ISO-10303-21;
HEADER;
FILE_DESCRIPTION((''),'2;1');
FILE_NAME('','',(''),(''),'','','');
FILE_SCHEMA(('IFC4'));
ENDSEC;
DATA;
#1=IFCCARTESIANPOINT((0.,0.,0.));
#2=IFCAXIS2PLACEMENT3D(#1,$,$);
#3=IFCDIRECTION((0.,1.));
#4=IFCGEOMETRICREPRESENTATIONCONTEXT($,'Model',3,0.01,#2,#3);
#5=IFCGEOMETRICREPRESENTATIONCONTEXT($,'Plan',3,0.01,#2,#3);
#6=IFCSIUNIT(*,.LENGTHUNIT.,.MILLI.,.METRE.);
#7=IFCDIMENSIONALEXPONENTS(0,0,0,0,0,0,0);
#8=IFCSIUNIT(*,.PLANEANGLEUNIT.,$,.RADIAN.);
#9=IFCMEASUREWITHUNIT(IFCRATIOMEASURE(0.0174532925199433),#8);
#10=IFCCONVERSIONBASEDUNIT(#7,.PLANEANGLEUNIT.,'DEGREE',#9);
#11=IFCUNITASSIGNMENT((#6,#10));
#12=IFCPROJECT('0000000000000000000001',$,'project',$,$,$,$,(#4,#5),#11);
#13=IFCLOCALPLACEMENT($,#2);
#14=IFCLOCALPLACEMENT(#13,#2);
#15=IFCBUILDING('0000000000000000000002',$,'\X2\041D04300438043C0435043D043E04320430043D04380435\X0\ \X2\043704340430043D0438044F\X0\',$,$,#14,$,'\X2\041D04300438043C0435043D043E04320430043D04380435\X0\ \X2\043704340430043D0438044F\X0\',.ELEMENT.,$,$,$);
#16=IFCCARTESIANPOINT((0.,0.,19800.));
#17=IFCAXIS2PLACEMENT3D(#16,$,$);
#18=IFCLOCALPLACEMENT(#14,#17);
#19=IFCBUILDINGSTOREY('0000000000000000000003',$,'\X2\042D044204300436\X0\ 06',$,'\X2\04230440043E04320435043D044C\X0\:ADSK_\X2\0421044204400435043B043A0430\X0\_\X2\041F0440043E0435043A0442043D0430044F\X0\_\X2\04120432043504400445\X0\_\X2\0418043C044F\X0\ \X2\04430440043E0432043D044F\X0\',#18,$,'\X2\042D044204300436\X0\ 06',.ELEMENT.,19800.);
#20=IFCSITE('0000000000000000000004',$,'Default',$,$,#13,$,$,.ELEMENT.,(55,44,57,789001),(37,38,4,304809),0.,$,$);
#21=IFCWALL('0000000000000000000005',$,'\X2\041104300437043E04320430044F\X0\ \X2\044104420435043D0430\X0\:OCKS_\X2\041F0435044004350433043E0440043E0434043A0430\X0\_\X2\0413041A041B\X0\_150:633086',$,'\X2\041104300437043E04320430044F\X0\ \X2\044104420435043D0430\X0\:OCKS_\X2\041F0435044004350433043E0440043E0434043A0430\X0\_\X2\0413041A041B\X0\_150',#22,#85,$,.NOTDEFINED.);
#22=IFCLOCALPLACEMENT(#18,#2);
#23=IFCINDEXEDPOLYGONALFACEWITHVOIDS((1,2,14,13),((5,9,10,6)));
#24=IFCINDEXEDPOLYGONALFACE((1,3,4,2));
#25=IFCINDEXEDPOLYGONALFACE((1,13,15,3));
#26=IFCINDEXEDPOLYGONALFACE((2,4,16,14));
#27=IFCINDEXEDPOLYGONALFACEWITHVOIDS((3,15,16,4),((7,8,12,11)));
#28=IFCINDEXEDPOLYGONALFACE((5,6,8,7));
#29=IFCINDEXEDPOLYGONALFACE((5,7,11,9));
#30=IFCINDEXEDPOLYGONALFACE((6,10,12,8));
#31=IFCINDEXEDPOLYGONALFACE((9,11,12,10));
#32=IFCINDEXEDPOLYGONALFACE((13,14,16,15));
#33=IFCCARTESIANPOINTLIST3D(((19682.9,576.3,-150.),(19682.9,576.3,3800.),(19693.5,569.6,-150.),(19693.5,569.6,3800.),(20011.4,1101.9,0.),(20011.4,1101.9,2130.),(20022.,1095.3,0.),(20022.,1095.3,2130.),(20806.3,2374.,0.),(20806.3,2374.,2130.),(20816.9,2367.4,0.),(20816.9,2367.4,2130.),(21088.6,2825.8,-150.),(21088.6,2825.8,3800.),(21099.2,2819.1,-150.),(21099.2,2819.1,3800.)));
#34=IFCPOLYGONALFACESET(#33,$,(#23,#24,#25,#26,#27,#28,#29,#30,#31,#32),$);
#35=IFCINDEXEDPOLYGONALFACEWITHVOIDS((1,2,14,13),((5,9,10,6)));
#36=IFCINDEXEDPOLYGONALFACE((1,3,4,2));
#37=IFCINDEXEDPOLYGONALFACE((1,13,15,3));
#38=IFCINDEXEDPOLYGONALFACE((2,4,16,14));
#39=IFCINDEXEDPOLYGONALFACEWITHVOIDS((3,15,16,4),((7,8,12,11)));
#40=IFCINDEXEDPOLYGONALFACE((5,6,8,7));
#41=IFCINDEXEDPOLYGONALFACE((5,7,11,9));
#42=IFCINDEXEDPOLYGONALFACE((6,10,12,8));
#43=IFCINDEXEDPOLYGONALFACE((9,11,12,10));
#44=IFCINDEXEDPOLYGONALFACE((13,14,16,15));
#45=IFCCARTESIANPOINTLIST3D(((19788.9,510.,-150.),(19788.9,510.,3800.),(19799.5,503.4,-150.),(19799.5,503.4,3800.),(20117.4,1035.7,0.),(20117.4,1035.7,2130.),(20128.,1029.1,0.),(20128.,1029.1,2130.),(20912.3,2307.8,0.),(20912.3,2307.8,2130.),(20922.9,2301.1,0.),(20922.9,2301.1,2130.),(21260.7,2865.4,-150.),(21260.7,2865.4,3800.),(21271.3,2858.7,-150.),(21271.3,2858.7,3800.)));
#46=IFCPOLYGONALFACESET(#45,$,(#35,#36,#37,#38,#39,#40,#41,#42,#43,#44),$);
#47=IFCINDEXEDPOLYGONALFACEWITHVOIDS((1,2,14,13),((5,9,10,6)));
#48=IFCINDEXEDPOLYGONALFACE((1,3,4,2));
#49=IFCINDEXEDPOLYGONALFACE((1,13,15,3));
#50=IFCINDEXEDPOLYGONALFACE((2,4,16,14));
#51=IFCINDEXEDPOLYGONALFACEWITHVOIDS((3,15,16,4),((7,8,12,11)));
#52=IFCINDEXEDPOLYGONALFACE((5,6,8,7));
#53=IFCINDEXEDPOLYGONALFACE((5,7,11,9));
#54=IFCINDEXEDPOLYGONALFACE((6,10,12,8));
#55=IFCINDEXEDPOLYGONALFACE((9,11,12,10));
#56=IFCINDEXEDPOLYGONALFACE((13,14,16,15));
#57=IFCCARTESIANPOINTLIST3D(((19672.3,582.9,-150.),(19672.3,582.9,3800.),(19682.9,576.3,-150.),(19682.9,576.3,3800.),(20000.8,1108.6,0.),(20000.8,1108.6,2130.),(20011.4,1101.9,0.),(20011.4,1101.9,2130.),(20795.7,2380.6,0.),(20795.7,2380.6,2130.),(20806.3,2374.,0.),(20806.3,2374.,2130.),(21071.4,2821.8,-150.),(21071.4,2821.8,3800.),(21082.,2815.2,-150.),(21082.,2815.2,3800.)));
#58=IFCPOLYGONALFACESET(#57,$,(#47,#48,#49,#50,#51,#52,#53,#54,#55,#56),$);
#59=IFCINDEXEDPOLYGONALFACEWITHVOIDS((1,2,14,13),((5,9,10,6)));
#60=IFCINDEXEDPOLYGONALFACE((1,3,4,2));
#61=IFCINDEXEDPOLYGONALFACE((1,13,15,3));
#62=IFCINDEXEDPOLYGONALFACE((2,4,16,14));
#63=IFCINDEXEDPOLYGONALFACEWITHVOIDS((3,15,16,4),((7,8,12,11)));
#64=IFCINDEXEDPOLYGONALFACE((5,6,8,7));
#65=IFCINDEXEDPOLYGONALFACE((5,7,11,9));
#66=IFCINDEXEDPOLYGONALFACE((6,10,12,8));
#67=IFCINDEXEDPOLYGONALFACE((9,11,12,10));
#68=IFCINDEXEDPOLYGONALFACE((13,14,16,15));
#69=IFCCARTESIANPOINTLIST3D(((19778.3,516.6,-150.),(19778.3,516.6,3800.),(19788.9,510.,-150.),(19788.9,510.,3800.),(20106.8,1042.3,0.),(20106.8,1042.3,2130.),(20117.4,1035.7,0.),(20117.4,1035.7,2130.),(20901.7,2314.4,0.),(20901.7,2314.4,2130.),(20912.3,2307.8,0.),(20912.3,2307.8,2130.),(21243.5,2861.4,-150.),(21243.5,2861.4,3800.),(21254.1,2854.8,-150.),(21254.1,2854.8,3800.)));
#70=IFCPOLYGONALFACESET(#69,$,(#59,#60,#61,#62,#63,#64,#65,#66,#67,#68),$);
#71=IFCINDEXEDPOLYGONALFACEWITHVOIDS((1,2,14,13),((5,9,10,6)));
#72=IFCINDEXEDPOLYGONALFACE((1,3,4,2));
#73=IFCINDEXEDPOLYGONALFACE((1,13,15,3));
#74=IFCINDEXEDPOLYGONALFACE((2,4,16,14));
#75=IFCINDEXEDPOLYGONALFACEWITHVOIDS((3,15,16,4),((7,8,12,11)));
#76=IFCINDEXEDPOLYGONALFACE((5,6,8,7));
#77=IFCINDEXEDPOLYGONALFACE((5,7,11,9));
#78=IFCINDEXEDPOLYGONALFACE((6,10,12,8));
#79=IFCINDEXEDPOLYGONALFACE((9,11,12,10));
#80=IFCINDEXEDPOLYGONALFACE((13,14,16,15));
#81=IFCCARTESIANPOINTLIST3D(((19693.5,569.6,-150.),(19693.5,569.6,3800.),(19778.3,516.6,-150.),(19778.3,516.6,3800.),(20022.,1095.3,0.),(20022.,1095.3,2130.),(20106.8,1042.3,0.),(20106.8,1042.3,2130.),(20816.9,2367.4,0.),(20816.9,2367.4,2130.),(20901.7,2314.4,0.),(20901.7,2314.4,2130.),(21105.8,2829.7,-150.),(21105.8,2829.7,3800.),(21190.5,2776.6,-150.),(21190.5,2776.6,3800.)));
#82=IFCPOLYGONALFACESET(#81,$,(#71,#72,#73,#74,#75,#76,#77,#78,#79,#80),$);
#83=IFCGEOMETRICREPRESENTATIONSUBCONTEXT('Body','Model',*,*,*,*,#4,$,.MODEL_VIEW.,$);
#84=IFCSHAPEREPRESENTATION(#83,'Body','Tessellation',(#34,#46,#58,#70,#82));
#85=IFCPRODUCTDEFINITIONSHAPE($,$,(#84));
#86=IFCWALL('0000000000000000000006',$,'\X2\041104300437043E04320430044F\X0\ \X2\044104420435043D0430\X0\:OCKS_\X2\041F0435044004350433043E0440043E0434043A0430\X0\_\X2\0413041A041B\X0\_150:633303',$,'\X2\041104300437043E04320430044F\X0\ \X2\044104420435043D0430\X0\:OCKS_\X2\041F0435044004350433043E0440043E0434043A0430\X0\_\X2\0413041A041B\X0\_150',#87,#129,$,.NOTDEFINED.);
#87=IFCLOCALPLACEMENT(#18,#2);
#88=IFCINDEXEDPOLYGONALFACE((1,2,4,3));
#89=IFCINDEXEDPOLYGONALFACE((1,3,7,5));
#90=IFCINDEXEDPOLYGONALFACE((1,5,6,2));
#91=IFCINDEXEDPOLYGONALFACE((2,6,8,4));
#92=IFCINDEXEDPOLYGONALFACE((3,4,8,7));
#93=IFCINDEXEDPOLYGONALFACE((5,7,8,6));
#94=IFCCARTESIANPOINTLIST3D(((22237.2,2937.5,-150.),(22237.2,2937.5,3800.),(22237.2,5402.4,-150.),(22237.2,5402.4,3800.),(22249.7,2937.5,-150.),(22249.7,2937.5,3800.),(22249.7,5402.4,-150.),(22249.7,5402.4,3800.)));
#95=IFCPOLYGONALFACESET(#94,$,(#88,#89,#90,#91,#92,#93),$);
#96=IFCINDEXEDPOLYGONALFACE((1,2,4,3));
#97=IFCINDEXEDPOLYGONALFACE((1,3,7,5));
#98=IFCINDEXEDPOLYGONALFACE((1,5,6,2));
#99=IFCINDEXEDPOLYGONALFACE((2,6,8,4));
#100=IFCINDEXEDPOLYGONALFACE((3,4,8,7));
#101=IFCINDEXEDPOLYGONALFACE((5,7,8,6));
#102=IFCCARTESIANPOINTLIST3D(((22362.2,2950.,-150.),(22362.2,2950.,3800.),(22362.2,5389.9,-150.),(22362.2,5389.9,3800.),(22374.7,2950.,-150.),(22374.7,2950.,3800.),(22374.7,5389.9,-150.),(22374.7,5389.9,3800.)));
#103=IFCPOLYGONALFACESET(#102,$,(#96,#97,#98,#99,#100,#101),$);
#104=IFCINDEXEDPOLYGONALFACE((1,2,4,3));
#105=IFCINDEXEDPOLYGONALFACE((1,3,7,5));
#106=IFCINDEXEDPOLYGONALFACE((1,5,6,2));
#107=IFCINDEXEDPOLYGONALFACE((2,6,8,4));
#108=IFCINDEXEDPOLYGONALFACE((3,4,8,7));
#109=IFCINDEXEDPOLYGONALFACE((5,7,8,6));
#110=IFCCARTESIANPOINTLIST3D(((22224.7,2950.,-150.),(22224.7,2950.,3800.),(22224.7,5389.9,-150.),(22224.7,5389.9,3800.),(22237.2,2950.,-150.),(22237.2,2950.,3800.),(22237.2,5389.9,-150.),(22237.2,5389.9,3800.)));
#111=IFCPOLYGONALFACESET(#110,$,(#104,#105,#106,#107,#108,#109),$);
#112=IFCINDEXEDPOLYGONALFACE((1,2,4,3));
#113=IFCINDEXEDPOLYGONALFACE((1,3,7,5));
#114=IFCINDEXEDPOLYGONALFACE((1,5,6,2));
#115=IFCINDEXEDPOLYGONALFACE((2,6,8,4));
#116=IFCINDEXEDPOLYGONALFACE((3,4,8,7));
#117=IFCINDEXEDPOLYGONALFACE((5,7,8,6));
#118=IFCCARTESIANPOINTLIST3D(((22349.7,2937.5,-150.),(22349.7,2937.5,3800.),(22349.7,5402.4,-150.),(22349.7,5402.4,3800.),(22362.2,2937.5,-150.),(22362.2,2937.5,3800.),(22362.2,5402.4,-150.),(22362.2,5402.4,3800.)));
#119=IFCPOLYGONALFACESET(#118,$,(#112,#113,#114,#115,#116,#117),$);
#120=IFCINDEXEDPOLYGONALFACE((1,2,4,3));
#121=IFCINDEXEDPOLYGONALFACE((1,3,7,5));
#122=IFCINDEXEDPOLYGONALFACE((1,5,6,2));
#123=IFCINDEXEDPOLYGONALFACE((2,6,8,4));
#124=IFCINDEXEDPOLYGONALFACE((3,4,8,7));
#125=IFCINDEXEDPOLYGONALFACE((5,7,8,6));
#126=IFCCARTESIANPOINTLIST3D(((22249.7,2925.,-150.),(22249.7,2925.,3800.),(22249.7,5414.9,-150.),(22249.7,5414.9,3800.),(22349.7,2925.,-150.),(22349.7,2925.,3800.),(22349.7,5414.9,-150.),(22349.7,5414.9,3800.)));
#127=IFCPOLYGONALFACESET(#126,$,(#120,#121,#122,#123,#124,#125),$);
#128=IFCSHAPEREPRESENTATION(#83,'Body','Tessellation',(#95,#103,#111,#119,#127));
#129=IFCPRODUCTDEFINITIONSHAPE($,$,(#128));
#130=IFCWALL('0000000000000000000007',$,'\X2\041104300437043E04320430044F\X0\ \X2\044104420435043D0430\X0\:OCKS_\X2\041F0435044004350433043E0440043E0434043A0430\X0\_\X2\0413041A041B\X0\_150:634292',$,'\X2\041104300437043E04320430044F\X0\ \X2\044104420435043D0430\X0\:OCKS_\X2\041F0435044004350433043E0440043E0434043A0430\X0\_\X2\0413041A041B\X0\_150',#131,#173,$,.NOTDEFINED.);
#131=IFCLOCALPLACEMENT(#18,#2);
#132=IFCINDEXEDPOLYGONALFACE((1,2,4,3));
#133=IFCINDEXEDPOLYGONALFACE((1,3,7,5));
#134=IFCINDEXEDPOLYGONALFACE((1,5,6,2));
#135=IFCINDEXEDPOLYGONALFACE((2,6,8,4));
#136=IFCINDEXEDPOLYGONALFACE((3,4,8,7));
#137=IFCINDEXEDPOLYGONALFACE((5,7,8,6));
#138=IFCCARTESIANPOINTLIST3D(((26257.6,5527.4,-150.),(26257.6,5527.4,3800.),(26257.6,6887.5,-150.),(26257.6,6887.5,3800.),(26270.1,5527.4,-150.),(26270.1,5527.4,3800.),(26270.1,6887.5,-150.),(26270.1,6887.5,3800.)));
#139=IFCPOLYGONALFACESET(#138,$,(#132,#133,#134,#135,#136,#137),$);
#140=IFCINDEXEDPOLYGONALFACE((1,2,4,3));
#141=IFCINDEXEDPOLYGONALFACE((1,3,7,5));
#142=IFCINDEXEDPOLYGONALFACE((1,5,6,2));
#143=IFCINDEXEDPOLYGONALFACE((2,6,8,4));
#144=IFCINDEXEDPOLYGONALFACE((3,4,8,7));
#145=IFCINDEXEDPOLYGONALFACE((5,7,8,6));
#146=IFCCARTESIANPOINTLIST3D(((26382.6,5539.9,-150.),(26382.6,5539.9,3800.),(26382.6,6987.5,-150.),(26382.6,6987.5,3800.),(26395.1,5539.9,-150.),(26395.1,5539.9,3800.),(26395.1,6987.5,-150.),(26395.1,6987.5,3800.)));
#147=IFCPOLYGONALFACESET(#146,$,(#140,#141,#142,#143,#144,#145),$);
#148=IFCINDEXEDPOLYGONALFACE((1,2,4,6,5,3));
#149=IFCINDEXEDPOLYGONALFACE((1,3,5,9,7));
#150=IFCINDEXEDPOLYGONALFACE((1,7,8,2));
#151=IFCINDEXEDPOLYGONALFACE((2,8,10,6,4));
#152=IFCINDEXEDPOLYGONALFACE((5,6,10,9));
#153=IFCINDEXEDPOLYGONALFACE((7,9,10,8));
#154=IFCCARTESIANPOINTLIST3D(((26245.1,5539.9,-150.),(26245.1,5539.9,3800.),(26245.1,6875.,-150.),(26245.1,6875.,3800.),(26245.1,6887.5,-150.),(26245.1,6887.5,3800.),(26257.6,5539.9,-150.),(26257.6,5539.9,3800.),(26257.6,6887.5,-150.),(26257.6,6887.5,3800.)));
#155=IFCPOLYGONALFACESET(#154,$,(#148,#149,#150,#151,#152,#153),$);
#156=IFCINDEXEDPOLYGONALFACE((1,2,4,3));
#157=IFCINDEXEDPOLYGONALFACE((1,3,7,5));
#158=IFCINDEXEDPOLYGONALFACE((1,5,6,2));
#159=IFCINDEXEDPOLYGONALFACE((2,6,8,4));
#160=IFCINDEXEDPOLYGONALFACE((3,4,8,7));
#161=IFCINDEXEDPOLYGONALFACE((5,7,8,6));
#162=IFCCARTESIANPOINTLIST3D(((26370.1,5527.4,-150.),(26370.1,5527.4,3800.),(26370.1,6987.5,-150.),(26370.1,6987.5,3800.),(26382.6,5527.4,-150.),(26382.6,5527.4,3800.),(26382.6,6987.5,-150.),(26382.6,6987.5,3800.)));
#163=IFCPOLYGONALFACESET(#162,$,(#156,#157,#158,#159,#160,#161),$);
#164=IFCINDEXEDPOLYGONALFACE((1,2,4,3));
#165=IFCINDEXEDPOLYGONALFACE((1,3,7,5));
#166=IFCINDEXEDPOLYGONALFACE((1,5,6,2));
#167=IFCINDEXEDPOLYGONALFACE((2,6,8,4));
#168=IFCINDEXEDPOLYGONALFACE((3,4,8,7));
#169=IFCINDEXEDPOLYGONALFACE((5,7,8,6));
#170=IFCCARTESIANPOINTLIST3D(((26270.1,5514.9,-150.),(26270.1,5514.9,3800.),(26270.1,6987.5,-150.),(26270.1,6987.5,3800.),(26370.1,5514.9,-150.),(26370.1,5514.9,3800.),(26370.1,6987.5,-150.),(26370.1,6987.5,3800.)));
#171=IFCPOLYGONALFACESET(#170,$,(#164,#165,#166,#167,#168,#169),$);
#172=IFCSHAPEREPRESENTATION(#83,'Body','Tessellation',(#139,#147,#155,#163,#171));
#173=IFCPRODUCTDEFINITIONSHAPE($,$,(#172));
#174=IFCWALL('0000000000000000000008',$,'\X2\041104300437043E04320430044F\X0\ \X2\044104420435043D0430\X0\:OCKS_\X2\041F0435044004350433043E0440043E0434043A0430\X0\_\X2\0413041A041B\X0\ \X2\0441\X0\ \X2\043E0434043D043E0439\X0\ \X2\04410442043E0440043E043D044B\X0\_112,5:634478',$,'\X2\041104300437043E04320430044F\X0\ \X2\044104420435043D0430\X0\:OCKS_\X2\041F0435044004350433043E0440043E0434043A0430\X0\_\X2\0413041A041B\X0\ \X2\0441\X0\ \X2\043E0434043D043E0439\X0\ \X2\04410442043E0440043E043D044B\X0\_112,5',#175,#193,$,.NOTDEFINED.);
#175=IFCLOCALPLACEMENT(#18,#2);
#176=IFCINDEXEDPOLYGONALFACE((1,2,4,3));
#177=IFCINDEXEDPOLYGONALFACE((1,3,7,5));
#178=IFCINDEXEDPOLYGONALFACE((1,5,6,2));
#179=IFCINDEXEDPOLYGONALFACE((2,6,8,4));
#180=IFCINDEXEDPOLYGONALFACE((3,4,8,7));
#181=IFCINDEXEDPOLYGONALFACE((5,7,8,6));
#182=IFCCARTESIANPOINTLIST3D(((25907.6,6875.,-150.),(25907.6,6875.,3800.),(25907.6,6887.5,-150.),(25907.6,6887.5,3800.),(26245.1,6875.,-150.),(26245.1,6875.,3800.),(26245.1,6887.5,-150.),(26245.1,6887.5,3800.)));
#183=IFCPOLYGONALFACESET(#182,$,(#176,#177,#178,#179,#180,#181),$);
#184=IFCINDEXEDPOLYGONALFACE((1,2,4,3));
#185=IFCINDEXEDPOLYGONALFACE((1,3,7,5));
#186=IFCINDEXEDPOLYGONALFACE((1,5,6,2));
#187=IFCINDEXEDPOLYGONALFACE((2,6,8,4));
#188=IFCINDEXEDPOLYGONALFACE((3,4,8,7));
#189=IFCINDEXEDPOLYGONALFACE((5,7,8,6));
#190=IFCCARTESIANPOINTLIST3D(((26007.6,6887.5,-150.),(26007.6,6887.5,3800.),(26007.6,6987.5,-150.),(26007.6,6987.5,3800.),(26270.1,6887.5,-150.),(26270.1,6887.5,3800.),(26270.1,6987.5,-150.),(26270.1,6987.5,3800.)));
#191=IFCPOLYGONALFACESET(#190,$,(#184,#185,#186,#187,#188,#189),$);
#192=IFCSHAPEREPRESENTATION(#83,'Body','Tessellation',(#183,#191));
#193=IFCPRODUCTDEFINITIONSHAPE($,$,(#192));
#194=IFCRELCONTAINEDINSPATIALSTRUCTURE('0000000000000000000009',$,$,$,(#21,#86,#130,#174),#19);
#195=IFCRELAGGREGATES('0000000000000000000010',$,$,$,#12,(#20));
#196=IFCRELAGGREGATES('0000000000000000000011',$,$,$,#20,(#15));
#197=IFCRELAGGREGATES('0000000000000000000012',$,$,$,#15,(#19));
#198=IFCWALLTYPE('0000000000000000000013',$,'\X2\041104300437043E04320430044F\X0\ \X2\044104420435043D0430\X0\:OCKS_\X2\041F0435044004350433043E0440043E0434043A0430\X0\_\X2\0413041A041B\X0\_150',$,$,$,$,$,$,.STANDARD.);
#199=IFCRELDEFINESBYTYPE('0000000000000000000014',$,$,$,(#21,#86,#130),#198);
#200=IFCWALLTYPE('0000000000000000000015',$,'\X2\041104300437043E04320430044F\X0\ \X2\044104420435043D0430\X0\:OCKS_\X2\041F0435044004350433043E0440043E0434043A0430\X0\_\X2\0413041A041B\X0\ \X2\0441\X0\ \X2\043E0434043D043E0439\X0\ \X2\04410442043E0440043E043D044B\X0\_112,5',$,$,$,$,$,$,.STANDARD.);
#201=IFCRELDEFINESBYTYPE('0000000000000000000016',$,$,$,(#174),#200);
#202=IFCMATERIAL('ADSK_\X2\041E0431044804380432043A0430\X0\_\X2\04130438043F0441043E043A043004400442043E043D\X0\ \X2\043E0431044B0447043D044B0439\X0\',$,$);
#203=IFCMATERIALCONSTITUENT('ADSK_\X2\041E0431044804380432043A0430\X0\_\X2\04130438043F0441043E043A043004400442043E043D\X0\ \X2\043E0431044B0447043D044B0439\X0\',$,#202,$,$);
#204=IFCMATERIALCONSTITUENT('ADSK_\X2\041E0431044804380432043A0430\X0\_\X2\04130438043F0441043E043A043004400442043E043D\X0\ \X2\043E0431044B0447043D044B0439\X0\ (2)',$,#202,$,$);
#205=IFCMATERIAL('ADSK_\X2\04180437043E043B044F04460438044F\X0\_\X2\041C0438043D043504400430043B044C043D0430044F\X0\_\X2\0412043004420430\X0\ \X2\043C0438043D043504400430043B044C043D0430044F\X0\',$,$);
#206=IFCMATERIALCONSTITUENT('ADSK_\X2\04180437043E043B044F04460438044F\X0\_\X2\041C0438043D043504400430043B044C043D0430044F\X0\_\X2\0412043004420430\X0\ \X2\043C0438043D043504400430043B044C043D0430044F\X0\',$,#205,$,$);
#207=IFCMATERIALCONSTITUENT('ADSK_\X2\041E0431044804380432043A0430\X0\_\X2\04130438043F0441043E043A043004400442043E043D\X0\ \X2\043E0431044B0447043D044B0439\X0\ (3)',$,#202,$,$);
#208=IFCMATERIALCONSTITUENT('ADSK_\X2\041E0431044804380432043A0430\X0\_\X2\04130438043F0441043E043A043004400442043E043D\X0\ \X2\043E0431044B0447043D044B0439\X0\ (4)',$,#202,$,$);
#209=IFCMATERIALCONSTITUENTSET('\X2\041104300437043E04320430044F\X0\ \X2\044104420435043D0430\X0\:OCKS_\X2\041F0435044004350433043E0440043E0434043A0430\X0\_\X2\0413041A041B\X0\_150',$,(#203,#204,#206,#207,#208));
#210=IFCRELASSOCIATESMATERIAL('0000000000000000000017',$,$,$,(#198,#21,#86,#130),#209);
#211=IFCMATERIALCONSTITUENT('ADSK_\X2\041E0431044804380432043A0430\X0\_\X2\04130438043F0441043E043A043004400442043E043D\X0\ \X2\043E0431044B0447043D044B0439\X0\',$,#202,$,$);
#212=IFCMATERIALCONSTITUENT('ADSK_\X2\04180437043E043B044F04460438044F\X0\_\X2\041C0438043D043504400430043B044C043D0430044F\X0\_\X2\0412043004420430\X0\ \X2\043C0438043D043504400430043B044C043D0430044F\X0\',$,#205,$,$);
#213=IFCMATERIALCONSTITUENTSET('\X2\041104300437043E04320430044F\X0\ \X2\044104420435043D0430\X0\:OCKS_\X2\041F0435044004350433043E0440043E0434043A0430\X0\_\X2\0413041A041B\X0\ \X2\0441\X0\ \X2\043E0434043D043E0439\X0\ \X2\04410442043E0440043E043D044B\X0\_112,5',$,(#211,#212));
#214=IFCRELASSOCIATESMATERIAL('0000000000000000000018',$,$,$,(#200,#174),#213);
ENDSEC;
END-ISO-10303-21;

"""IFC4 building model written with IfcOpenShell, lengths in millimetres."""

from ifc_helpers import new_model, entity, si_unit, converted_unit, direction, frame, origin, place, context, subcontext, project, spatial, indexed_curve, outline, extrude, material, constituent, constituent_set, type_object, element, save


model = new_model("IFC4")

# Units and contexts
model_context = context("Model", 3, precision=0.01, world=origin(), true_north=direction((0.0, 1.0)))
plan_context = context("Plan", 3, precision=0.01, world=origin(), true_north=direction((0.0, 1.0)))
body_context = subcontext(model_context, "Body", "Model", "MODEL_VIEW")
ifc_project = project(units=[si_unit("LENGTHUNIT", "METRE", prefix="MILLI"), converted_unit("PLANEANGLEUNIT", "DEGREE", entity("IfcRatioMeasure", 0.0174532925199433), si_unit("PLANEANGLEUNIT", "RADIAN"), dimensions=[0, 0, 0, 0, 0, 0, 0])], contexts=[model_context, plan_context])

# Site, building, storey
site_placement = place(None, frame((0.0, 0.0, 0.0)))
site = spatial("IfcSite", under=ifc_project, at=site_placement, Name="Default", CompositionType="ELEMENT", RefLatitude=(55, 44, 57, 789001), RefLongitude=(37, 38, 4, 304809), RefElevation=0.0)
building_placement = place(site_placement, origin())
building = spatial("IfcBuilding", under=site, at=building_placement, Name="Наименование здания", LongName="Наименование здания", CompositionType="ELEMENT")
storey_placement = place(building_placement, frame((0.0, 0.0, 19800.0)))
storey = spatial("IfcBuildingStorey", under=building, at=storey_placement, Name="Этаж 06", ObjectType="Уровень:ADSK_Стрелка_Проектная_Вверх_Имя уровня", LongName="Этаж 06", CompositionType="ELEMENT", Elevation=19800.0)

# Shared definitions
ifc_material_1 = material(Name="ADSK_Обшивка_Гипсокартон обычный")
ifc_constituent_1 = constituent(ifc_material_1, Name="ADSK_Обшивка_Гипсокартон обычный")
ifc_constituent_2 = constituent(ifc_material_1, Name="ADSK_Обшивка_Гипсокартон обычный (2)")
ifc_material_2 = material(Name="ADSK_Изоляция_Минеральная_Вата минеральная")
ifc_constituent_3 = constituent(ifc_material_2, Name="ADSK_Изоляция_Минеральная_Вата минеральная")
ifc_constituent_4 = constituent(ifc_material_1, Name="ADSK_Обшивка_Гипсокартон обычный (3)")
ifc_constituent_5 = constituent(ifc_material_1, Name="ADSK_Обшивка_Гипсокартон обычный (4)")
ifc_constituent_set_1 = constituent_set(constituents=[ifc_constituent_1, ifc_constituent_2, ifc_constituent_3, ifc_constituent_4, ifc_constituent_5], Name="Базовая стена:OCKS_Перегородка_ГКЛ_150")
wall_type_1 = type_object("IfcWallType", Name="Базовая стена:OCKS_Перегородка_ГКЛ_150", PredefinedType="STANDARD", material=ifc_constituent_set_1)

# Wall, opening
wall_1_placement = place(storey_placement, frame((21135.0, 2782.1, -150.0), z_axis=(0.0, 0.0, 1.0), x_axis=(-0.529921, -0.848047, 0.0)))
wall_1 = element("IfcWall", 1, at=wall_1_placement, inside=storey, type_object=wall_type_1, material=ifc_constituent_set_1, Name="Базовая стена:OCKS_Перегородка_ГКЛ_150:633086", ObjectType="Базовая стена:OCKS_Перегородка_ГКЛ_150", PredefinedType="NOTDEFINED", context=body_context, shape_type="SweptSolid", body=[
    extrude(outline(indexed_curve([(-1326.3, -6.2), (1326.3, -6.2), (1326.3, 6.3), (-1326.3, 6.2), (-1326.3, -6.2)], self_intersect=False)), frame((1313.8, -56.3, 0.0)), (0.0, 0.0, 1.0), 3950.0),
    extrude(outline(indexed_curve([(-4.5, -1388.7), (8.0, -1388.7), (4.5, 1388.7), (-8.0, 1388.7), (-4.5, -1388.7)], self_intersect=False)), frame((1251.4, 68.7, 0.0), z_axis=(0.0, 0.0, 1.0), x_axis=(-0.001294, -0.999999, 0.0)), (0.0, 0.0, 1.0), 3950.0),
    extrude(outline(indexed_curve([(-6.2, -1320.0), (6.3, -1320.0), (6.2, 1320.0), (-6.3, 1320.0), (-6.2, -1320.0)], self_intersect=False)), frame((1320.0, -68.7, 0.0), z_axis=(0.0, 0.0, 1.0), x_axis=(0.0, 1.0, 0.0)), (0.0, 0.0, 1.0), 3950.0),
    extrude(outline(indexed_curve([(-1382.5, -6.2), (1382.5, -6.2), (1382.5, 6.3), (-1382.4, 6.2), (-1382.5, -6.2)], self_intersect=False)), frame((1257.6, 56.2, 0.0)), (0.0, 0.0, 1.0), 3950.0),
    extrude(outline(indexed_curve([(-1332.6, -50.0), (1332.5, -50.0), (1332.5, 50.0), (-1332.4, 50.0), (-1332.6, -50.0)], self_intersect=False)), frame((1307.6, 0.0, 0.0)), (0.0, 0.0, 1.0), 3950.0),
])
opening_1_placement = place(wall_1_placement, frame((13559.2, -16449.2, 150.0), z_axis=(0.0, 0.0, 1.0), x_axis=(-0.529921, 0.848047, 0.0)))
element("IfcOpeningElement", 2, at=opening_1_placement, cuts=wall_1, PredefinedType="OPENING", context=body_context, shape_type="SweptSolid", body=[
    extrude(outline(indexed_curve([(-750.0, -1065.0), (750.0, -1065.0), (750.0, 1065.0), (-750.0, 1065.0), (-750.0, -1065.0)], self_intersect=False)), frame((19889.4, 2062.6, 1065.0), z_axis=(0.848047, -0.529921, 0.0), x_axis=(-0.529921, -0.848047, 0.0)), (0.0, 0.0, 1.0), 1350.0),
])

# Wall
wall_2_placement = place(storey_placement, frame((22299.7, 2950.0, -150.0), z_axis=(0.0, 0.0, 1.0), x_axis=(0.0, 1.0, 0.0)))
element("IfcWall", 3, at=wall_2_placement, inside=storey, type_object=wall_type_1, material=ifc_constituent_set_1, Name="Базовая стена:OCKS_Перегородка_ГКЛ_150:633303", ObjectType="Базовая стена:OCKS_Перегородка_ГКЛ_150", PredefinedType="NOTDEFINED", context=body_context, shape_type="SweptSolid", body=[
    extrude(outline(indexed_curve([(-1232.5, -6.2), (1232.5, -6.2), (1232.5, 6.3), (-1232.5, 6.3), (-1232.5, -6.2)], self_intersect=False)), frame((1220.0, 56.2, 0.0)), (0.0, 0.0, 1.0), 3950.0),
    extrude(outline(indexed_curve([(-6.3, -1220.0), (6.2, -1220.0), (6.3, 1220.0), (-6.2, 1220.0), (-6.3, -1220.0)], self_intersect=False)), frame((1220.0, -68.7, 0.0), z_axis=(0.0, 0.0, 1.0), x_axis=(0.0, 1.0, 0.0)), (0.0, 0.0, 1.0), 3950.0),
    extrude(outline(indexed_curve([(-6.3, -1220.0), (6.2, -1220.0), (6.3, 1220.0), (-6.2, 1220.0), (-6.3, -1220.0)], self_intersect=False)), frame((1220.0, 68.8, 0.0), z_axis=(0.0, 0.0, 1.0), x_axis=(0.0, -1.0, 0.0)), (0.0, 0.0, 1.0), 3950.0),
    extrude(outline(indexed_curve([(-1232.5, -6.2), (1232.5, -6.2), (1232.5, 6.3), (-1232.5, 6.3), (-1232.5, -6.2)], self_intersect=False)), frame((1220.0, -56.3, 0.0)), (0.0, 0.0, 1.0), 3950.0),
    extrude(outline(indexed_curve([(-1245.0, -50.0), (1245.0, -50.0), (1245.0, 50.0), (-1245.0, 50.0), (-1245.0, -50.0)], self_intersect=False)), frame((1220.0, 0.0, 0.0)), (0.0, 0.0, 1.0), 3950.0),
])

# Wall
wall_3_placement = place(storey_placement, frame((26320.1, 5539.9, -150.0), z_axis=(0.0, 0.0, 1.0), x_axis=(0.0, 1.0, 0.0)))
element("IfcWall", 4, at=wall_3_placement, inside=storey, type_object=wall_type_1, material=ifc_constituent_set_1, Name="Базовая стена:OCKS_Перегородка_ГКЛ_150:634292", ObjectType="Базовая стена:OCKS_Перегородка_ГКЛ_150", PredefinedType="NOTDEFINED", context=body_context, shape_type="SweptSolid", body=[
    extrude(outline(indexed_curve([(-680.0, -6.2), (680.0, -6.2), (680.0, 6.2), (-680.0, 6.2), (-680.0, -6.2)], self_intersect=False)), frame((667.5, 56.3, 0.0)), (0.0, 0.0, 1.0), 3950.0),
    extrude(outline(indexed_curve([(-6.3, -723.8), (6.2, -723.8), (6.2, 723.8), (-6.3, 723.8), (-6.3, -723.8)], self_intersect=False)), frame((723.8, -68.7, 0.0), z_axis=(0.0, 0.0, 1.0), x_axis=(0.0, 1.0, 0.0)), (0.0, 0.0, 1.0), 3950.0),
    extrude(outline(indexed_curve([(-529.0, -5.0), (806.0, -5.0), (806.0, 7.5), (-541.5, 7.5), (-541.5, -5.0), (-529.0, -5.0)], self_intersect=False)), frame((806.0, 70.0, 0.0), z_axis=(0.0, 0.0, 1.0), x_axis=(-1.0, 0.0, 0.0)), (0.0, 0.0, 1.0), 3950.0),
    extrude(outline(indexed_curve([(-730.0, -6.2), (730.0, -6.2), (730.0, 6.2), (-730.0, 6.2), (-730.0, -6.2)], self_intersect=False)), frame((717.5, -56.3, 0.0)), (0.0, 0.0, 1.0), 3950.0),
    extrude(outline(indexed_curve([(-736.3, -50.0), (736.3, -50.0), (736.3, 50.0), (-736.3, 50.0), (-736.3, -50.0)], self_intersect=False)), frame((711.3, 0.0, 0.0)), (0.0, 0.0, 1.0), 3950.0),
])

# Wall
ifc_constituent_6 = constituent(ifc_material_1, Name="ADSK_Обшивка_Гипсокартон обычный")
ifc_constituent_7 = constituent(ifc_material_2, Name="ADSK_Изоляция_Минеральная_Вата минеральная")
ifc_constituent_set_2 = constituent_set(constituents=[ifc_constituent_6, ifc_constituent_7], Name="Базовая стена:OCKS_Перегородка_ГКЛ с одной стороны_112,5")
wall_type_2 = type_object("IfcWallType", Name="Базовая стена:OCKS_Перегородка_ГКЛ с одной стороны_112,5", PredefinedType="STANDARD", material=ifc_constituent_set_2)
wall_4_placement = place(storey_placement, frame((26007.6, 6931.2, -150.0)))
element("IfcWall", 5, at=wall_4_placement, inside=storey, type_object=wall_type_2, material=ifc_constituent_set_2, Name="Базовая стена:OCKS_Перегородка_ГКЛ с одной стороны_112,5:634478", ObjectType="Базовая стена:OCKS_Перегородка_ГКЛ с одной стороны_112,5", PredefinedType="NOTDEFINED", context=body_context, shape_type="SweptSolid", body=[
    extrude(outline(indexed_curve([(-6.3, -168.7), (6.2, -168.7), (6.3, 168.7), (-6.2, 168.7), (-6.3, -168.7)], self_intersect=False)), frame((68.7, -50.0, 0.0), z_axis=(0.0, 0.0, 1.0), x_axis=(0.0, 1.0, 0.0)), (0.0, 0.0, 1.0), 3950.0),
    extrude(outline(indexed_curve([(-50.0, -131.2), (50.0, -131.2), (50.0, 131.2), (-50.0, 131.2), (-50.0, -131.2)], self_intersect=False)), frame((131.2, 6.3, 0.0), z_axis=(0.0, 0.0, 1.0), x_axis=(0.0, -1.0, 0.0)), (0.0, 0.0, 1.0), 3950.0),
])

save(model, "model.ifc")
